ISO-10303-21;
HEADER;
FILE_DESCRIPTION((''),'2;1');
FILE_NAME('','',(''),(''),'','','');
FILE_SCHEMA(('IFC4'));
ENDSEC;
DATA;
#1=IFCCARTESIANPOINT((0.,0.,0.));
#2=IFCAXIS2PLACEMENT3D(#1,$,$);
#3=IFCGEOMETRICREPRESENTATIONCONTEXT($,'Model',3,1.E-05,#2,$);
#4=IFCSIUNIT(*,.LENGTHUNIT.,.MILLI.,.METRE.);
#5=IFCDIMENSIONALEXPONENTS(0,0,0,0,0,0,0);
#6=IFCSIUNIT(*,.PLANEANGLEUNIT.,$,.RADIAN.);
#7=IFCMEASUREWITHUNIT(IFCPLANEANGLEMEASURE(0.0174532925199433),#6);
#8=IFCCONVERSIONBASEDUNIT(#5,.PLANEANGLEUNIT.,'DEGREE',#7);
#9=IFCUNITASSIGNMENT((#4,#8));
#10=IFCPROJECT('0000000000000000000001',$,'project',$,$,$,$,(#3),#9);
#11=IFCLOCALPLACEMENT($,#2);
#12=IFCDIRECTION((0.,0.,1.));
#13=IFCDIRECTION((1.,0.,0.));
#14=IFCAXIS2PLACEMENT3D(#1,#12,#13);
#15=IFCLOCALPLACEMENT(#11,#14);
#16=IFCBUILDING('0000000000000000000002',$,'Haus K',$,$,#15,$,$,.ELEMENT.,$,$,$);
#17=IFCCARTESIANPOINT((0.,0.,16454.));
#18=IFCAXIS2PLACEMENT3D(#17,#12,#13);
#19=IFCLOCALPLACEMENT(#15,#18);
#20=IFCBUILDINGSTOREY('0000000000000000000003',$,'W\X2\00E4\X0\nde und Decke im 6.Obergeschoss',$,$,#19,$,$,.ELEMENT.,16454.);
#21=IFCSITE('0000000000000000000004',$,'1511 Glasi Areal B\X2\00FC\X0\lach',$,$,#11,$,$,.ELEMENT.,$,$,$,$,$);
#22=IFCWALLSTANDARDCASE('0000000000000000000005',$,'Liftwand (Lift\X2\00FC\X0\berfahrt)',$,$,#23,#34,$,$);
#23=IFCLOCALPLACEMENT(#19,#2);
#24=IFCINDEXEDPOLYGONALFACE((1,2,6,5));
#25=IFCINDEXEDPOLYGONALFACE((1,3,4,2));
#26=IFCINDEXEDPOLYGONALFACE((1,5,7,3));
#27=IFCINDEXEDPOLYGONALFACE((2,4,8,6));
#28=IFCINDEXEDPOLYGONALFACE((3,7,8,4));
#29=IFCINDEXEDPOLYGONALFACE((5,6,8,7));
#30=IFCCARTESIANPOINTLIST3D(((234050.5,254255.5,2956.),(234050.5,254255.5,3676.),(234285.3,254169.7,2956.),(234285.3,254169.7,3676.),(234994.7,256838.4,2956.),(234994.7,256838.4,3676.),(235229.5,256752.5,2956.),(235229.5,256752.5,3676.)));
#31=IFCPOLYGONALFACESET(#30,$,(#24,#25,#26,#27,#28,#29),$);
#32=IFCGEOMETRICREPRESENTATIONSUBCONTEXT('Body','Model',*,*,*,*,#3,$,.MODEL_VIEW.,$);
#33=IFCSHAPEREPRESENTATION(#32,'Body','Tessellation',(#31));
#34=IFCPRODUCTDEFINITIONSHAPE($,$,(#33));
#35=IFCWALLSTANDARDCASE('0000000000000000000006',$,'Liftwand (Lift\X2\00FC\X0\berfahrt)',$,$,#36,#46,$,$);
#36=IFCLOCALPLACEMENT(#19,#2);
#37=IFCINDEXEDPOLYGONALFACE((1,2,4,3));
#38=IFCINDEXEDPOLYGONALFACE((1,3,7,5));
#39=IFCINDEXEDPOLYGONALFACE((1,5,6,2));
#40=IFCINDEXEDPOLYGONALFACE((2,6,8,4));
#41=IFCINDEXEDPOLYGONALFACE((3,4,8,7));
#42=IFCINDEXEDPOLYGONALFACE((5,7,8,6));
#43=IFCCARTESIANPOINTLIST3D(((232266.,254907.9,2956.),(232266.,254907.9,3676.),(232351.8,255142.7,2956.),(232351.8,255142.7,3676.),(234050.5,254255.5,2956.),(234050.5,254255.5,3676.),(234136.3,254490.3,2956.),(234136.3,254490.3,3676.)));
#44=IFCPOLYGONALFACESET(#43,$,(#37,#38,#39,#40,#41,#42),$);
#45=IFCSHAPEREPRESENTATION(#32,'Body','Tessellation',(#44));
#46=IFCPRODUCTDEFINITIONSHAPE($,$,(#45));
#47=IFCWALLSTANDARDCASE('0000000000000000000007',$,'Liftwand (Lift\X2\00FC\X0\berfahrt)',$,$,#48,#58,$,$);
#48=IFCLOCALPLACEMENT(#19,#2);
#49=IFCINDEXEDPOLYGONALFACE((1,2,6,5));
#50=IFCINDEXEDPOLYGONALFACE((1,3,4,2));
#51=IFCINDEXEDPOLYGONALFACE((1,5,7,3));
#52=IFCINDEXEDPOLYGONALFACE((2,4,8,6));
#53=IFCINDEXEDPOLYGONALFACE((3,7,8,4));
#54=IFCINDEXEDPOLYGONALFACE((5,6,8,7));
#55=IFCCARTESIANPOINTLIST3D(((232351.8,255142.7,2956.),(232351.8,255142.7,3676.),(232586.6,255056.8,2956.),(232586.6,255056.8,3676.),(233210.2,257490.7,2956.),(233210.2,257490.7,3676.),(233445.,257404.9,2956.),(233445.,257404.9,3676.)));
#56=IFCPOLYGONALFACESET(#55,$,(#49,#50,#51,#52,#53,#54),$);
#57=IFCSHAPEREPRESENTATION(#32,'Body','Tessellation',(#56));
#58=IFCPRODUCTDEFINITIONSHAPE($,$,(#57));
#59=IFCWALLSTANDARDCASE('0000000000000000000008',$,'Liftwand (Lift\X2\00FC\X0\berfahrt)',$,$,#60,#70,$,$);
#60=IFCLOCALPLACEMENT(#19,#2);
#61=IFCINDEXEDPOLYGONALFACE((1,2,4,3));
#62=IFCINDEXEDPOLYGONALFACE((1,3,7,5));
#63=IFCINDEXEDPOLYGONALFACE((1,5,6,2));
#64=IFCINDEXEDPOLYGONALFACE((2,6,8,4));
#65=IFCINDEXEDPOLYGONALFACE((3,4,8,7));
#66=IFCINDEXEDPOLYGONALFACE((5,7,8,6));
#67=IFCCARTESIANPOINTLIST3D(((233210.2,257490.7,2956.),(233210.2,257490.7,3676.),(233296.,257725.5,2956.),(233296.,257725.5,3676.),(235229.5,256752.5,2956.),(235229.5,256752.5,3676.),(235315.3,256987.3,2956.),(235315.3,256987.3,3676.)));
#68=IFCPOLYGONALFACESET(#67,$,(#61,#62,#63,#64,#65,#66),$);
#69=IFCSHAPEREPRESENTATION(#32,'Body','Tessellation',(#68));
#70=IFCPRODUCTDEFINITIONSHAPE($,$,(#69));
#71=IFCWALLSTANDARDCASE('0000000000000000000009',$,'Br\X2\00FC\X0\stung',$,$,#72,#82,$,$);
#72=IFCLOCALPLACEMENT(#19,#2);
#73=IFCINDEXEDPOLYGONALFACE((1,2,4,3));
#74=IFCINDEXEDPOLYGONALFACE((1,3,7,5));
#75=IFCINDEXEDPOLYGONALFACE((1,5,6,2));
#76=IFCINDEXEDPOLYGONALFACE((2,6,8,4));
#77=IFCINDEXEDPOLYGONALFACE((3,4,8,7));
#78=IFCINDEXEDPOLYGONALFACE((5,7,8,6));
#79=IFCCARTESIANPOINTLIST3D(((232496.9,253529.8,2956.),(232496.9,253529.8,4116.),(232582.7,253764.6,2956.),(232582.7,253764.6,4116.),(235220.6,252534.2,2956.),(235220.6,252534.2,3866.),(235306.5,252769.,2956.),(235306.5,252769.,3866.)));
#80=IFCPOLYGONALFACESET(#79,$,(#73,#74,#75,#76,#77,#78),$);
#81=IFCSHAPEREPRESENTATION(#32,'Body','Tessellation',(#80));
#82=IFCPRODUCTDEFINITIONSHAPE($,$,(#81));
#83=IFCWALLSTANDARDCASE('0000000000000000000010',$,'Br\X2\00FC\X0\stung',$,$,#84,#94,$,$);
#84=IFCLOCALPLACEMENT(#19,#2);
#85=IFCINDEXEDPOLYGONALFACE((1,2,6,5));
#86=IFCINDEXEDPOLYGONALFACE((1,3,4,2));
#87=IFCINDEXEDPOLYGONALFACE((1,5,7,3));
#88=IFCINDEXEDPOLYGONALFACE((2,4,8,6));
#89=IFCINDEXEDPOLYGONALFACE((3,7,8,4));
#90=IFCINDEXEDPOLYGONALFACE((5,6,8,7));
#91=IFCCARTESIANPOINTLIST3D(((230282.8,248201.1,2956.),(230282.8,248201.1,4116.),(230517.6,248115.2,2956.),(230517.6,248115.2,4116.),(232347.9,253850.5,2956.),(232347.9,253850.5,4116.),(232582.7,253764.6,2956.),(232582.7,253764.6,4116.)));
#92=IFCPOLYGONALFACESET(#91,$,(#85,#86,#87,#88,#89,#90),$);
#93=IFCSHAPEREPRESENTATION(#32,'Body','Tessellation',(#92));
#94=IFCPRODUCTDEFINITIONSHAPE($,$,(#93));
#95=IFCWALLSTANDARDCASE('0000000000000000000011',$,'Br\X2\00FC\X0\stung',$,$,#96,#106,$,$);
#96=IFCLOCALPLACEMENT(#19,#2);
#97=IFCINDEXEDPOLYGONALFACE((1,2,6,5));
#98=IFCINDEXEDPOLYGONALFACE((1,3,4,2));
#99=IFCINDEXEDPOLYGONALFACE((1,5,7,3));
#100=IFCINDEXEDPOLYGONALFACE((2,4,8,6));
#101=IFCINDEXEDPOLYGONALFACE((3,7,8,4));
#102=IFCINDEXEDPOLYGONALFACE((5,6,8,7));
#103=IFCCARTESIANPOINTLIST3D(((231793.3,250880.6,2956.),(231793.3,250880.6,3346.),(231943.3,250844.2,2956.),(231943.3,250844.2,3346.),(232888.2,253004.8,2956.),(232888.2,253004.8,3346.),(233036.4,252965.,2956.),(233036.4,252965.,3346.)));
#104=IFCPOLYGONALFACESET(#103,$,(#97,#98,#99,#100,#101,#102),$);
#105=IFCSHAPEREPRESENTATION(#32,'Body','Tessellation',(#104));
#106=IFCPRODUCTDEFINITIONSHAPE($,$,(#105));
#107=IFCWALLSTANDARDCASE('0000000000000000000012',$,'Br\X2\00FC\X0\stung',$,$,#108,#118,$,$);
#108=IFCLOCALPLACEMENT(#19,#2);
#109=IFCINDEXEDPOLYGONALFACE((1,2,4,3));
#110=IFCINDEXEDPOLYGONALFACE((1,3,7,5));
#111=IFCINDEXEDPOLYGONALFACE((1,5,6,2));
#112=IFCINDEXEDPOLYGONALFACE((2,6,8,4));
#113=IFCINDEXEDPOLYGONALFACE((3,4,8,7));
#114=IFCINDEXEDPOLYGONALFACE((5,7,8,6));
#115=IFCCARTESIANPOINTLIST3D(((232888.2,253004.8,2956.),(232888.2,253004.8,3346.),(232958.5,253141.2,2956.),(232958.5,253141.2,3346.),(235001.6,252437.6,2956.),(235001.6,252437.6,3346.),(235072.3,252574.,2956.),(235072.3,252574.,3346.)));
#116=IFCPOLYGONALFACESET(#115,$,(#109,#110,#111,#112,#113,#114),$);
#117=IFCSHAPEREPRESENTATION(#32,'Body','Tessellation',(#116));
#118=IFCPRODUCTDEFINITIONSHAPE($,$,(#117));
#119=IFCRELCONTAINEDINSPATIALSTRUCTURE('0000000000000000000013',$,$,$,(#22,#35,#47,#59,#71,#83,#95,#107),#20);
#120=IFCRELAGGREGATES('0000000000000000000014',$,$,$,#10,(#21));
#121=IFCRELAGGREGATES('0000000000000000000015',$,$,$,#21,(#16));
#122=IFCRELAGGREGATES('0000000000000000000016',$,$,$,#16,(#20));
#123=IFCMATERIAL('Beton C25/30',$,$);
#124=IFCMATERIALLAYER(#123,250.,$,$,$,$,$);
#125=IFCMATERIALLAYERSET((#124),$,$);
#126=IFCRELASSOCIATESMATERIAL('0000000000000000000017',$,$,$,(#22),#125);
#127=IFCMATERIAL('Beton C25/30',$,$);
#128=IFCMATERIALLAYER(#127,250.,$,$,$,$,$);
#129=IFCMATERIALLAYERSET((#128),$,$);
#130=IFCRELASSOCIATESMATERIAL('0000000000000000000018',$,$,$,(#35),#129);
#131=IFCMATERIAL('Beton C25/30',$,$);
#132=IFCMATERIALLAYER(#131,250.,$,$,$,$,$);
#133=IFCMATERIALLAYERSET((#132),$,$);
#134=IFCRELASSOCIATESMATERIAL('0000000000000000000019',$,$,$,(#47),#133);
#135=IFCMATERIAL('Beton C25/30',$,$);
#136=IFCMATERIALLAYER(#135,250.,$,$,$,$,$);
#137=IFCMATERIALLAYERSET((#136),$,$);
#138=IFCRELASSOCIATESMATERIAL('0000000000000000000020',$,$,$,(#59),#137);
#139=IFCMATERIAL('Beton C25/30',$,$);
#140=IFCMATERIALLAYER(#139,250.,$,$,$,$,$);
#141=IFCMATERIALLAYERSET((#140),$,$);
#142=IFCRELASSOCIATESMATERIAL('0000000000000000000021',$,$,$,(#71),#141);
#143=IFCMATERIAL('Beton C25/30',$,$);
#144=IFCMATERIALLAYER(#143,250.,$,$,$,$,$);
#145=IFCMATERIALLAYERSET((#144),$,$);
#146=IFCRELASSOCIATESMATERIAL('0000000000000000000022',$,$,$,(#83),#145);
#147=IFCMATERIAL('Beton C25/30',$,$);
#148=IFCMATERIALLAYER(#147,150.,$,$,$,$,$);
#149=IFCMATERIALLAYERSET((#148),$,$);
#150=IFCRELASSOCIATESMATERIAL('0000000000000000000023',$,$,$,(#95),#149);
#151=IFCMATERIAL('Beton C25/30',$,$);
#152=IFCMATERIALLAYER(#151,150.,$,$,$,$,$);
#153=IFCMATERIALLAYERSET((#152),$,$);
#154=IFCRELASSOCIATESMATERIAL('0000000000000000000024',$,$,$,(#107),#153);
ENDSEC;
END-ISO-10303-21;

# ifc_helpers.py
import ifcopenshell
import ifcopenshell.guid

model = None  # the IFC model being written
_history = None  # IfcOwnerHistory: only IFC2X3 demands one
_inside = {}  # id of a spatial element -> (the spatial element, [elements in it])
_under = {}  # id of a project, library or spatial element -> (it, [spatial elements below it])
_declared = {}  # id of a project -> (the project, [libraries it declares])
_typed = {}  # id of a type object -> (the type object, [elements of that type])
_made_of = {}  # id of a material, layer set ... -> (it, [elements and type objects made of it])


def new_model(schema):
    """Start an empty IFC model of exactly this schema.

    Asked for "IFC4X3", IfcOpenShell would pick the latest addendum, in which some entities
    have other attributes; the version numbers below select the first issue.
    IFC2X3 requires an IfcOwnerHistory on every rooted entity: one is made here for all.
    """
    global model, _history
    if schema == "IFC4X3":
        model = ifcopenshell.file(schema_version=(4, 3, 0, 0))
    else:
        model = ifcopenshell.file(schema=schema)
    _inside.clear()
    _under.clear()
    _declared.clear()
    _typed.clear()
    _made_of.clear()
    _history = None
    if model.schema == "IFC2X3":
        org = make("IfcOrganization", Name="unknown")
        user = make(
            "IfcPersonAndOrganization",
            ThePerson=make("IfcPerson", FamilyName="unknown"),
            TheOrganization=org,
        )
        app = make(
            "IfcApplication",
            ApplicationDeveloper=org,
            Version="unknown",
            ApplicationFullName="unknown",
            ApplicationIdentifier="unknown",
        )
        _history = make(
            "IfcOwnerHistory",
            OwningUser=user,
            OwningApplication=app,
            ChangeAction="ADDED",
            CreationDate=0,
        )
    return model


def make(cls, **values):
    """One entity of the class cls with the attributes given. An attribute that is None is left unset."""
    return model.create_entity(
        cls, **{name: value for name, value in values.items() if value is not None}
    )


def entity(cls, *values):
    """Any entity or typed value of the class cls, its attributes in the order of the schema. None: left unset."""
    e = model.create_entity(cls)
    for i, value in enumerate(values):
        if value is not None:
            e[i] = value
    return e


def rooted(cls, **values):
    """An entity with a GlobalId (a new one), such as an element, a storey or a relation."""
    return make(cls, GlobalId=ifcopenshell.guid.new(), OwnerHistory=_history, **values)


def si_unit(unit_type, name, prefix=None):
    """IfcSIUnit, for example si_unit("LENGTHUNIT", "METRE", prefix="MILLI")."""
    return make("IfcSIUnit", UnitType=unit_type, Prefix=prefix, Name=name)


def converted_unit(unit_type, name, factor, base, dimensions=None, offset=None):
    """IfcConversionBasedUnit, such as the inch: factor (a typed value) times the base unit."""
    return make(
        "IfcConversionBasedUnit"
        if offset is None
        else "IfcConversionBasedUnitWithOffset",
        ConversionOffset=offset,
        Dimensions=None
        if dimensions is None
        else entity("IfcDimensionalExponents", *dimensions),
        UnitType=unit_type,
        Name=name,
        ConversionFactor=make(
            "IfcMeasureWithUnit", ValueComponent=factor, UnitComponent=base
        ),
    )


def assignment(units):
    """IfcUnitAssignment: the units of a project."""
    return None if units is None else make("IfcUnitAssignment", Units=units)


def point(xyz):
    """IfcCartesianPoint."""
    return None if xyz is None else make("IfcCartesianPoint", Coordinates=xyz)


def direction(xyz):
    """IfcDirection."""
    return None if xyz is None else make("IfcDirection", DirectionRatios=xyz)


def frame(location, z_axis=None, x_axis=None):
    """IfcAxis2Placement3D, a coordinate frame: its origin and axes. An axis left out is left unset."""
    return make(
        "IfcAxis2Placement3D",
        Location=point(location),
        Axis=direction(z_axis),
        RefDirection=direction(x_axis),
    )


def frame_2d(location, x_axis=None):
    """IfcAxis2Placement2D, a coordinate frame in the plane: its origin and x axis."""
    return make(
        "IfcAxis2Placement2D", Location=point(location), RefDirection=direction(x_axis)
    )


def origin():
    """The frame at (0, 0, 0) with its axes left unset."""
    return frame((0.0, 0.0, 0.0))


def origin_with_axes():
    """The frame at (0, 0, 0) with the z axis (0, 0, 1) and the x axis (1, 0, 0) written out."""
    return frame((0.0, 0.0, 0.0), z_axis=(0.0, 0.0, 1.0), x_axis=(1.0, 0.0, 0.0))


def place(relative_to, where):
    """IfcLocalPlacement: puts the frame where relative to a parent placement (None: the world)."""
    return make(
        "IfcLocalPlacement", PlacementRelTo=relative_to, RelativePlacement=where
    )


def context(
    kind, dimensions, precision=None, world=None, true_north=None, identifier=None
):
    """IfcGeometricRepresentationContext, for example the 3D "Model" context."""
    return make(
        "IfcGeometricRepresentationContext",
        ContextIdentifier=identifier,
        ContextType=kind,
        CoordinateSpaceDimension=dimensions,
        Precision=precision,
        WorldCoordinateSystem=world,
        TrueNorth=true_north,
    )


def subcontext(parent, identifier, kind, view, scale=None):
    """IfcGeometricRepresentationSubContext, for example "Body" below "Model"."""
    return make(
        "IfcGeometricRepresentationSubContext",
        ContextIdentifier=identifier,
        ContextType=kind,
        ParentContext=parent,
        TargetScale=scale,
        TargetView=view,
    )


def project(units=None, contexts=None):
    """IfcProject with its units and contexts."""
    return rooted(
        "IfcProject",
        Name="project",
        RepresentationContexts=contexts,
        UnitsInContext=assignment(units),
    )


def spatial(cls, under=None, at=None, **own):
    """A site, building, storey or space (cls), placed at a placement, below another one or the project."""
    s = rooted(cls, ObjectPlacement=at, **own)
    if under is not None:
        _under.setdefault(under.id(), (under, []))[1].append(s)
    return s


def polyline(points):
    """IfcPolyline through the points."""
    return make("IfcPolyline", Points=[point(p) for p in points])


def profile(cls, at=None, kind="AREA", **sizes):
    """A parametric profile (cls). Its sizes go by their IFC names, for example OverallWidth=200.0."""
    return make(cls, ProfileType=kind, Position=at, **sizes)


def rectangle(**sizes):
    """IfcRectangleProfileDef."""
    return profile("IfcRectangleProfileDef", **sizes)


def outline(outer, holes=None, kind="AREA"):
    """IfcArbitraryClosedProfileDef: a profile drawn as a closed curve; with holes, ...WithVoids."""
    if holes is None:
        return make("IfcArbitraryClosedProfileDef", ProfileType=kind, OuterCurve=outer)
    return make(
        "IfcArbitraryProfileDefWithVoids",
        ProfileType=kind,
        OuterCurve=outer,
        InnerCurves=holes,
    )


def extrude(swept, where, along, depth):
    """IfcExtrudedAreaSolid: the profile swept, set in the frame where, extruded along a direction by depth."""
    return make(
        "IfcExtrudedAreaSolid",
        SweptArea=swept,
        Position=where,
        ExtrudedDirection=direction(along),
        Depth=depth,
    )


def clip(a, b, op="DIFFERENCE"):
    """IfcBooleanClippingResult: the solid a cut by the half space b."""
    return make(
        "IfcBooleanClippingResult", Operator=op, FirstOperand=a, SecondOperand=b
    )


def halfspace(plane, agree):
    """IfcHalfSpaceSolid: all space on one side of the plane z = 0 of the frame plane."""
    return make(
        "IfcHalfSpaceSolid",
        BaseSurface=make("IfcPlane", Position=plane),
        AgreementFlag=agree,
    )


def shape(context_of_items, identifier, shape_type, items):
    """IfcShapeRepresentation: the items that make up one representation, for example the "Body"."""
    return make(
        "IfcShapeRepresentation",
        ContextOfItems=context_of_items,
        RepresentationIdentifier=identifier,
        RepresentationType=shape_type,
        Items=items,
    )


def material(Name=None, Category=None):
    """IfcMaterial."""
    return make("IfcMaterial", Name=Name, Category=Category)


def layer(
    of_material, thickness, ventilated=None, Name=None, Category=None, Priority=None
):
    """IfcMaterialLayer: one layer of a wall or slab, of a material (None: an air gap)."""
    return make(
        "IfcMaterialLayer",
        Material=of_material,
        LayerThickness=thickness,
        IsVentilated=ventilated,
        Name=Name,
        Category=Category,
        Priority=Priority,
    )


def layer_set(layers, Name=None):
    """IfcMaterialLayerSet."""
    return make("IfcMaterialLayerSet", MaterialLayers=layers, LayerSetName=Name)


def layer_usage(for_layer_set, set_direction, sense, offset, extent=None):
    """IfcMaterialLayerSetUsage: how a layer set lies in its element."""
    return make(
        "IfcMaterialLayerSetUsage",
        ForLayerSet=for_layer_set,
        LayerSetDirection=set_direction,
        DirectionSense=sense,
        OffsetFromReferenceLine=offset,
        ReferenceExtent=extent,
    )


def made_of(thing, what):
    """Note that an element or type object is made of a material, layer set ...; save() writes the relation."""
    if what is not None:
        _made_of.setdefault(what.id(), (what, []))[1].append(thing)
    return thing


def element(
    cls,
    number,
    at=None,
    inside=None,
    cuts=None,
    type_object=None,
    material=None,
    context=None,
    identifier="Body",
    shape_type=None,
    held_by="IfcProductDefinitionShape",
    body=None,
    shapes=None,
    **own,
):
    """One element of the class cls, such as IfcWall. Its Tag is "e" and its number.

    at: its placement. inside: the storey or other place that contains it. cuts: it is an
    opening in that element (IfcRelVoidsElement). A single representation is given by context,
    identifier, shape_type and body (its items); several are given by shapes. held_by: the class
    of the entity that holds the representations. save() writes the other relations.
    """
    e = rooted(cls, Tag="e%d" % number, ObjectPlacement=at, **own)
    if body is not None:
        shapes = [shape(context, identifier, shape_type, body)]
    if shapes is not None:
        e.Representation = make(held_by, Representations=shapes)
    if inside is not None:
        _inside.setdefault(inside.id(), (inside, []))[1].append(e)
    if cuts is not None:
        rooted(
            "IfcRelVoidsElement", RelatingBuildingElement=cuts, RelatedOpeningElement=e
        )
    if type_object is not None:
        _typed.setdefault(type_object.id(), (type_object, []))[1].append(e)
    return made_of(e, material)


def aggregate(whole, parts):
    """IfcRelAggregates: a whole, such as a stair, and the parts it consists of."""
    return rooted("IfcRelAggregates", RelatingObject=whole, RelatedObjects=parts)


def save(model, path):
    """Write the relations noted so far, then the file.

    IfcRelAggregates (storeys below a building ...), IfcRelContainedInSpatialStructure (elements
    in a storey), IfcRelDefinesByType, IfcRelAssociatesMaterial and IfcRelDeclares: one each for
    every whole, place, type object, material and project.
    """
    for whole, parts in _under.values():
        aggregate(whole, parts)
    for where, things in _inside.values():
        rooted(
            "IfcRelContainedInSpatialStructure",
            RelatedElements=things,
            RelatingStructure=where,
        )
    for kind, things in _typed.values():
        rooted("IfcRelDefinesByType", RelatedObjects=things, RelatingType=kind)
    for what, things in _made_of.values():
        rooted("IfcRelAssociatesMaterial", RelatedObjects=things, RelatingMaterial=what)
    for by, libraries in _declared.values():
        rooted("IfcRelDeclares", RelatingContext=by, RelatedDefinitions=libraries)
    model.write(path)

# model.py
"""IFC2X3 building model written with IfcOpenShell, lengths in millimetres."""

from ifc_helpers import new_model, entity, si_unit, converted_unit, frame, frame_2d, origin, origin_with_axes, place, context, subcontext, project, spatial, polyline, rectangle, outline, extrude, clip, halfspace, material, layer, layer_set, layer_usage, element, save


model = new_model("IFC2X3")

# Units and contexts
model_context = context("Model", 3, precision=1e-05, world=origin())
body_context = subcontext(model_context, "Body", "Model", "MODEL_VIEW")
ifc_project = project(units=[si_unit("LENGTHUNIT", "METRE", prefix="MILLI"), converted_unit("PLANEANGLEUNIT", "DEGREE", entity("IfcPlaneAngleMeasure", 0.0174532925199433), si_unit("PLANEANGLEUNIT", "RADIAN"), dimensions=[0, 0, 0, 0, 0, 0, 0])], contexts=[model_context])

# Site, building, storey
site_placement = place(None, origin())
site = spatial("IfcSite", under=ifc_project, at=site_placement, Name="1511 Glasi Areal Bülach", CompositionType="ELEMENT")
building_placement = place(site_placement, origin_with_axes())
building = spatial("IfcBuilding", under=site, at=building_placement, Name="Haus K", CompositionType="ELEMENT")
storey_placement = place(building_placement, frame((0.0, 0.0, 16454.0), z_axis=(0.0, 0.0, 1.0), x_axis=(1.0, 0.0, 0.0)))
storey = spatial("IfcBuildingStorey", under=building, at=storey_placement, Name="Wände und Decke im 6.Obergeschoss", CompositionType="ELEMENT", Elevation=16454.0)

# Walls
ifc_material_1 = material(Name="Beton C25/30")
ifc_layer_1 = layer(ifc_material_1, 250.0)
ifc_layer_set_1 = layer_set([ifc_layer_1])
ifc_layer_usage_1 = layer_usage(ifc_layer_set_1, "AXIS2", "POSITIVE", 0.0)
wall_1_placement = place(storey_placement, frame((234285.3, 254169.7, 2956.0), z_axis=(0.0, 0.0, 1.0), x_axis=(0.343332, 0.939214, 0.0)))
element("IfcWallStandardCase", 1, at=wall_1_placement, inside=storey, material=ifc_layer_usage_1, Name="Liftwand (Liftüberfahrt)", context=body_context, shape_type="SweptSolid", body=[
    extrude(rectangle(XDim=2750.0, YDim=250.0, at=frame_2d((1375.0, 125.0), x_axis=(1.0, 0.0))), origin_with_axes(), (0.0, 0.0, 1.0), 720.0),
])
ifc_material_2 = material(Name="Beton C25/30")
ifc_layer_2 = layer(ifc_material_2, 250.0)
ifc_layer_set_2 = layer_set([ifc_layer_2])
ifc_layer_usage_2 = layer_usage(ifc_layer_set_2, "AXIS2", "POSITIVE", 0.0)
wall_2_placement = place(storey_placement, frame((232266.0, 254907.9, 2956.0), z_axis=(0.0, 0.0, 1.0), x_axis=(0.939214, -0.343332, 0.0)))
element("IfcWallStandardCase", 2, at=wall_2_placement, inside=storey, material=ifc_layer_usage_2, Name="Liftwand (Liftüberfahrt)", context=body_context, shape_type="SweptSolid", body=[
    extrude(rectangle(XDim=1900.0, YDim=250.0, at=frame_2d((950.0, 125.0), x_axis=(1.0, 0.0))), origin_with_axes(), (0.0, 0.0, 1.0), 720.0),
])
ifc_material_3 = material(Name="Beton C25/30")
ifc_layer_3 = layer(ifc_material_3, 250.0)
ifc_layer_set_3 = layer_set([ifc_layer_3])
ifc_layer_usage_3 = layer_usage(ifc_layer_set_3, "AXIS2", "POSITIVE", 0.0)
wall_3_placement = place(storey_placement, frame((233210.2, 257490.7, 2956.0), z_axis=(0.0, 0.0, 1.0), x_axis=(-0.343332, -0.939214, 0.0)))
element("IfcWallStandardCase", 3, at=wall_3_placement, inside=storey, material=ifc_layer_usage_3, Name="Liftwand (Liftüberfahrt)", context=body_context, shape_type="SweptSolid", body=[
    extrude(rectangle(XDim=2500.0, YDim=250.0, at=frame_2d((1250.0, 125.0), x_axis=(1.0, 0.0))), origin_with_axes(), (0.0, 0.0, 1.0), 720.0),
])
ifc_material_4 = material(Name="Beton C25/30")
ifc_layer_4 = layer(ifc_material_4, 250.0)
ifc_layer_set_4 = layer_set([ifc_layer_4])
ifc_layer_usage_4 = layer_usage(ifc_layer_set_4, "AXIS2", "POSITIVE", 0.0)
wall_4_placement = place(storey_placement, frame((235315.3, 256987.3, 2956.0), z_axis=(0.0, 0.0, 1.0), x_axis=(-0.939214, 0.343332, 0.0)))
element("IfcWallStandardCase", 4, at=wall_4_placement, inside=storey, material=ifc_layer_usage_4, Name="Liftwand (Liftüberfahrt)", context=body_context, shape_type="SweptSolid", body=[
    extrude(rectangle(XDim=2150.0, YDim=250.0, at=frame_2d((1075.0, 125.0), x_axis=(1.0, 0.0))), origin_with_axes(), (0.0, 0.0, 1.0), 720.0),
])
ifc_material_5 = material(Name="Beton C25/30")
ifc_layer_5 = layer(ifc_material_5, 250.0)
ifc_layer_set_5 = layer_set([ifc_layer_5])
ifc_layer_usage_5 = layer_usage(ifc_layer_set_5, "AXIS2", "POSITIVE", 0.0)
wall_5_placement = place(storey_placement, frame((235306.5, 252769.0, 2956.0), z_axis=(0.0, 0.0, 1.0), x_axis=(-0.939214, 0.343332, 0.0)))
element("IfcWallStandardCase", 5, at=wall_5_placement, inside=storey, material=ifc_layer_usage_5, Name="Brüstung", context=body_context, shape_type="Clipping", body=[
    clip(extrude(rectangle(XDim=2900.0, YDim=250.0, at=frame_2d((1450.0, 125.0), x_axis=(1.0, 0.0))), origin_with_axes(), (0.0, 0.0, 1.0), 1160.0), halfspace(frame((0.0, 250.0, 910.0), z_axis=(0.085888, 0.0, -0.996305), x_axis=(0.0, -1.0, 0.0)), True)),
])
ifc_material_6 = material(Name="Beton C25/30")
ifc_layer_6 = layer(ifc_material_6, 250.0)
ifc_layer_set_6 = layer_set([ifc_layer_6])
ifc_layer_usage_6 = layer_usage(ifc_layer_set_6, "AXIS2", "POSITIVE", 0.0)
wall_6_placement = place(storey_placement, frame((232347.9, 253850.5, 2956.0), z_axis=(0.0, 0.0, 1.0), x_axis=(-0.343332, -0.939214, 0.0)))
element("IfcWallStandardCase", 6, at=wall_6_placement, inside=storey, material=ifc_layer_usage_6, Name="Brüstung", context=body_context, shape_type="SweptSolid", body=[
    extrude(rectangle(XDim=6015.0, YDim=250.0, at=frame_2d((3007.5, 125.0), x_axis=(1.0, 0.0))), origin_with_axes(), (0.0, 0.0, 1.0), 1160.0),
])
ifc_material_7 = material(Name="Beton C25/30")
ifc_layer_7 = layer(ifc_material_7, 150.0)
ifc_layer_set_7 = layer_set([ifc_layer_7])
ifc_layer_usage_7 = layer_usage(ifc_layer_set_7, "AXIS2", "POSITIVE", 0.0)
wall_7_placement = place(storey_placement, frame((232888.2, 253004.8, 2956.0), z_axis=(0.0, 0.0, 1.0), x_axis=(-0.458138, -0.888881, 0.0)))
element("IfcWallStandardCase", 7, at=wall_7_placement, inside=storey, material=ifc_layer_usage_7, Name="Brüstung", context=body_context, shape_type="SweptSolid", body=[
    extrude(outline(polyline([(0.0, 0.0), (2389.7, 0.0), (2353.4, 150.0), (-32.6, 150.0), (0.0, 0.0)])), origin_with_axes(), (0.0, 0.0, 1.0), 390.0),
])
ifc_material_8 = material(Name="Beton C25/30")
ifc_layer_8 = layer(ifc_material_8, 150.0)
ifc_layer_set_8 = layer_set([ifc_layer_8])
ifc_layer_usage_8 = layer_usage(ifc_layer_set_8, "AXIS2", "POSITIVE", 0.0)
wall_8_placement = place(storey_placement, frame((235072.3, 252574.0, 2956.0), z_axis=(0.0, 0.0, 1.0), x_axis=(-0.965826, 0.259191, 0.0)))
element("IfcWallStandardCase", 8, at=wall_8_placement, inside=storey, material=ifc_layer_usage_8, Name="Brüstung", context=body_context, shape_type="SweptSolid", body=[
    extrude(outline(polyline([(0.0, 0.0), (2188.6, 0.0), (2221.2, 150.0), (32.9, 150.0), (0.0, 0.0)])), origin_with_axes(), (0.0, 0.0, 1.0), 390.0),
])

save(model, "model.ifc")
